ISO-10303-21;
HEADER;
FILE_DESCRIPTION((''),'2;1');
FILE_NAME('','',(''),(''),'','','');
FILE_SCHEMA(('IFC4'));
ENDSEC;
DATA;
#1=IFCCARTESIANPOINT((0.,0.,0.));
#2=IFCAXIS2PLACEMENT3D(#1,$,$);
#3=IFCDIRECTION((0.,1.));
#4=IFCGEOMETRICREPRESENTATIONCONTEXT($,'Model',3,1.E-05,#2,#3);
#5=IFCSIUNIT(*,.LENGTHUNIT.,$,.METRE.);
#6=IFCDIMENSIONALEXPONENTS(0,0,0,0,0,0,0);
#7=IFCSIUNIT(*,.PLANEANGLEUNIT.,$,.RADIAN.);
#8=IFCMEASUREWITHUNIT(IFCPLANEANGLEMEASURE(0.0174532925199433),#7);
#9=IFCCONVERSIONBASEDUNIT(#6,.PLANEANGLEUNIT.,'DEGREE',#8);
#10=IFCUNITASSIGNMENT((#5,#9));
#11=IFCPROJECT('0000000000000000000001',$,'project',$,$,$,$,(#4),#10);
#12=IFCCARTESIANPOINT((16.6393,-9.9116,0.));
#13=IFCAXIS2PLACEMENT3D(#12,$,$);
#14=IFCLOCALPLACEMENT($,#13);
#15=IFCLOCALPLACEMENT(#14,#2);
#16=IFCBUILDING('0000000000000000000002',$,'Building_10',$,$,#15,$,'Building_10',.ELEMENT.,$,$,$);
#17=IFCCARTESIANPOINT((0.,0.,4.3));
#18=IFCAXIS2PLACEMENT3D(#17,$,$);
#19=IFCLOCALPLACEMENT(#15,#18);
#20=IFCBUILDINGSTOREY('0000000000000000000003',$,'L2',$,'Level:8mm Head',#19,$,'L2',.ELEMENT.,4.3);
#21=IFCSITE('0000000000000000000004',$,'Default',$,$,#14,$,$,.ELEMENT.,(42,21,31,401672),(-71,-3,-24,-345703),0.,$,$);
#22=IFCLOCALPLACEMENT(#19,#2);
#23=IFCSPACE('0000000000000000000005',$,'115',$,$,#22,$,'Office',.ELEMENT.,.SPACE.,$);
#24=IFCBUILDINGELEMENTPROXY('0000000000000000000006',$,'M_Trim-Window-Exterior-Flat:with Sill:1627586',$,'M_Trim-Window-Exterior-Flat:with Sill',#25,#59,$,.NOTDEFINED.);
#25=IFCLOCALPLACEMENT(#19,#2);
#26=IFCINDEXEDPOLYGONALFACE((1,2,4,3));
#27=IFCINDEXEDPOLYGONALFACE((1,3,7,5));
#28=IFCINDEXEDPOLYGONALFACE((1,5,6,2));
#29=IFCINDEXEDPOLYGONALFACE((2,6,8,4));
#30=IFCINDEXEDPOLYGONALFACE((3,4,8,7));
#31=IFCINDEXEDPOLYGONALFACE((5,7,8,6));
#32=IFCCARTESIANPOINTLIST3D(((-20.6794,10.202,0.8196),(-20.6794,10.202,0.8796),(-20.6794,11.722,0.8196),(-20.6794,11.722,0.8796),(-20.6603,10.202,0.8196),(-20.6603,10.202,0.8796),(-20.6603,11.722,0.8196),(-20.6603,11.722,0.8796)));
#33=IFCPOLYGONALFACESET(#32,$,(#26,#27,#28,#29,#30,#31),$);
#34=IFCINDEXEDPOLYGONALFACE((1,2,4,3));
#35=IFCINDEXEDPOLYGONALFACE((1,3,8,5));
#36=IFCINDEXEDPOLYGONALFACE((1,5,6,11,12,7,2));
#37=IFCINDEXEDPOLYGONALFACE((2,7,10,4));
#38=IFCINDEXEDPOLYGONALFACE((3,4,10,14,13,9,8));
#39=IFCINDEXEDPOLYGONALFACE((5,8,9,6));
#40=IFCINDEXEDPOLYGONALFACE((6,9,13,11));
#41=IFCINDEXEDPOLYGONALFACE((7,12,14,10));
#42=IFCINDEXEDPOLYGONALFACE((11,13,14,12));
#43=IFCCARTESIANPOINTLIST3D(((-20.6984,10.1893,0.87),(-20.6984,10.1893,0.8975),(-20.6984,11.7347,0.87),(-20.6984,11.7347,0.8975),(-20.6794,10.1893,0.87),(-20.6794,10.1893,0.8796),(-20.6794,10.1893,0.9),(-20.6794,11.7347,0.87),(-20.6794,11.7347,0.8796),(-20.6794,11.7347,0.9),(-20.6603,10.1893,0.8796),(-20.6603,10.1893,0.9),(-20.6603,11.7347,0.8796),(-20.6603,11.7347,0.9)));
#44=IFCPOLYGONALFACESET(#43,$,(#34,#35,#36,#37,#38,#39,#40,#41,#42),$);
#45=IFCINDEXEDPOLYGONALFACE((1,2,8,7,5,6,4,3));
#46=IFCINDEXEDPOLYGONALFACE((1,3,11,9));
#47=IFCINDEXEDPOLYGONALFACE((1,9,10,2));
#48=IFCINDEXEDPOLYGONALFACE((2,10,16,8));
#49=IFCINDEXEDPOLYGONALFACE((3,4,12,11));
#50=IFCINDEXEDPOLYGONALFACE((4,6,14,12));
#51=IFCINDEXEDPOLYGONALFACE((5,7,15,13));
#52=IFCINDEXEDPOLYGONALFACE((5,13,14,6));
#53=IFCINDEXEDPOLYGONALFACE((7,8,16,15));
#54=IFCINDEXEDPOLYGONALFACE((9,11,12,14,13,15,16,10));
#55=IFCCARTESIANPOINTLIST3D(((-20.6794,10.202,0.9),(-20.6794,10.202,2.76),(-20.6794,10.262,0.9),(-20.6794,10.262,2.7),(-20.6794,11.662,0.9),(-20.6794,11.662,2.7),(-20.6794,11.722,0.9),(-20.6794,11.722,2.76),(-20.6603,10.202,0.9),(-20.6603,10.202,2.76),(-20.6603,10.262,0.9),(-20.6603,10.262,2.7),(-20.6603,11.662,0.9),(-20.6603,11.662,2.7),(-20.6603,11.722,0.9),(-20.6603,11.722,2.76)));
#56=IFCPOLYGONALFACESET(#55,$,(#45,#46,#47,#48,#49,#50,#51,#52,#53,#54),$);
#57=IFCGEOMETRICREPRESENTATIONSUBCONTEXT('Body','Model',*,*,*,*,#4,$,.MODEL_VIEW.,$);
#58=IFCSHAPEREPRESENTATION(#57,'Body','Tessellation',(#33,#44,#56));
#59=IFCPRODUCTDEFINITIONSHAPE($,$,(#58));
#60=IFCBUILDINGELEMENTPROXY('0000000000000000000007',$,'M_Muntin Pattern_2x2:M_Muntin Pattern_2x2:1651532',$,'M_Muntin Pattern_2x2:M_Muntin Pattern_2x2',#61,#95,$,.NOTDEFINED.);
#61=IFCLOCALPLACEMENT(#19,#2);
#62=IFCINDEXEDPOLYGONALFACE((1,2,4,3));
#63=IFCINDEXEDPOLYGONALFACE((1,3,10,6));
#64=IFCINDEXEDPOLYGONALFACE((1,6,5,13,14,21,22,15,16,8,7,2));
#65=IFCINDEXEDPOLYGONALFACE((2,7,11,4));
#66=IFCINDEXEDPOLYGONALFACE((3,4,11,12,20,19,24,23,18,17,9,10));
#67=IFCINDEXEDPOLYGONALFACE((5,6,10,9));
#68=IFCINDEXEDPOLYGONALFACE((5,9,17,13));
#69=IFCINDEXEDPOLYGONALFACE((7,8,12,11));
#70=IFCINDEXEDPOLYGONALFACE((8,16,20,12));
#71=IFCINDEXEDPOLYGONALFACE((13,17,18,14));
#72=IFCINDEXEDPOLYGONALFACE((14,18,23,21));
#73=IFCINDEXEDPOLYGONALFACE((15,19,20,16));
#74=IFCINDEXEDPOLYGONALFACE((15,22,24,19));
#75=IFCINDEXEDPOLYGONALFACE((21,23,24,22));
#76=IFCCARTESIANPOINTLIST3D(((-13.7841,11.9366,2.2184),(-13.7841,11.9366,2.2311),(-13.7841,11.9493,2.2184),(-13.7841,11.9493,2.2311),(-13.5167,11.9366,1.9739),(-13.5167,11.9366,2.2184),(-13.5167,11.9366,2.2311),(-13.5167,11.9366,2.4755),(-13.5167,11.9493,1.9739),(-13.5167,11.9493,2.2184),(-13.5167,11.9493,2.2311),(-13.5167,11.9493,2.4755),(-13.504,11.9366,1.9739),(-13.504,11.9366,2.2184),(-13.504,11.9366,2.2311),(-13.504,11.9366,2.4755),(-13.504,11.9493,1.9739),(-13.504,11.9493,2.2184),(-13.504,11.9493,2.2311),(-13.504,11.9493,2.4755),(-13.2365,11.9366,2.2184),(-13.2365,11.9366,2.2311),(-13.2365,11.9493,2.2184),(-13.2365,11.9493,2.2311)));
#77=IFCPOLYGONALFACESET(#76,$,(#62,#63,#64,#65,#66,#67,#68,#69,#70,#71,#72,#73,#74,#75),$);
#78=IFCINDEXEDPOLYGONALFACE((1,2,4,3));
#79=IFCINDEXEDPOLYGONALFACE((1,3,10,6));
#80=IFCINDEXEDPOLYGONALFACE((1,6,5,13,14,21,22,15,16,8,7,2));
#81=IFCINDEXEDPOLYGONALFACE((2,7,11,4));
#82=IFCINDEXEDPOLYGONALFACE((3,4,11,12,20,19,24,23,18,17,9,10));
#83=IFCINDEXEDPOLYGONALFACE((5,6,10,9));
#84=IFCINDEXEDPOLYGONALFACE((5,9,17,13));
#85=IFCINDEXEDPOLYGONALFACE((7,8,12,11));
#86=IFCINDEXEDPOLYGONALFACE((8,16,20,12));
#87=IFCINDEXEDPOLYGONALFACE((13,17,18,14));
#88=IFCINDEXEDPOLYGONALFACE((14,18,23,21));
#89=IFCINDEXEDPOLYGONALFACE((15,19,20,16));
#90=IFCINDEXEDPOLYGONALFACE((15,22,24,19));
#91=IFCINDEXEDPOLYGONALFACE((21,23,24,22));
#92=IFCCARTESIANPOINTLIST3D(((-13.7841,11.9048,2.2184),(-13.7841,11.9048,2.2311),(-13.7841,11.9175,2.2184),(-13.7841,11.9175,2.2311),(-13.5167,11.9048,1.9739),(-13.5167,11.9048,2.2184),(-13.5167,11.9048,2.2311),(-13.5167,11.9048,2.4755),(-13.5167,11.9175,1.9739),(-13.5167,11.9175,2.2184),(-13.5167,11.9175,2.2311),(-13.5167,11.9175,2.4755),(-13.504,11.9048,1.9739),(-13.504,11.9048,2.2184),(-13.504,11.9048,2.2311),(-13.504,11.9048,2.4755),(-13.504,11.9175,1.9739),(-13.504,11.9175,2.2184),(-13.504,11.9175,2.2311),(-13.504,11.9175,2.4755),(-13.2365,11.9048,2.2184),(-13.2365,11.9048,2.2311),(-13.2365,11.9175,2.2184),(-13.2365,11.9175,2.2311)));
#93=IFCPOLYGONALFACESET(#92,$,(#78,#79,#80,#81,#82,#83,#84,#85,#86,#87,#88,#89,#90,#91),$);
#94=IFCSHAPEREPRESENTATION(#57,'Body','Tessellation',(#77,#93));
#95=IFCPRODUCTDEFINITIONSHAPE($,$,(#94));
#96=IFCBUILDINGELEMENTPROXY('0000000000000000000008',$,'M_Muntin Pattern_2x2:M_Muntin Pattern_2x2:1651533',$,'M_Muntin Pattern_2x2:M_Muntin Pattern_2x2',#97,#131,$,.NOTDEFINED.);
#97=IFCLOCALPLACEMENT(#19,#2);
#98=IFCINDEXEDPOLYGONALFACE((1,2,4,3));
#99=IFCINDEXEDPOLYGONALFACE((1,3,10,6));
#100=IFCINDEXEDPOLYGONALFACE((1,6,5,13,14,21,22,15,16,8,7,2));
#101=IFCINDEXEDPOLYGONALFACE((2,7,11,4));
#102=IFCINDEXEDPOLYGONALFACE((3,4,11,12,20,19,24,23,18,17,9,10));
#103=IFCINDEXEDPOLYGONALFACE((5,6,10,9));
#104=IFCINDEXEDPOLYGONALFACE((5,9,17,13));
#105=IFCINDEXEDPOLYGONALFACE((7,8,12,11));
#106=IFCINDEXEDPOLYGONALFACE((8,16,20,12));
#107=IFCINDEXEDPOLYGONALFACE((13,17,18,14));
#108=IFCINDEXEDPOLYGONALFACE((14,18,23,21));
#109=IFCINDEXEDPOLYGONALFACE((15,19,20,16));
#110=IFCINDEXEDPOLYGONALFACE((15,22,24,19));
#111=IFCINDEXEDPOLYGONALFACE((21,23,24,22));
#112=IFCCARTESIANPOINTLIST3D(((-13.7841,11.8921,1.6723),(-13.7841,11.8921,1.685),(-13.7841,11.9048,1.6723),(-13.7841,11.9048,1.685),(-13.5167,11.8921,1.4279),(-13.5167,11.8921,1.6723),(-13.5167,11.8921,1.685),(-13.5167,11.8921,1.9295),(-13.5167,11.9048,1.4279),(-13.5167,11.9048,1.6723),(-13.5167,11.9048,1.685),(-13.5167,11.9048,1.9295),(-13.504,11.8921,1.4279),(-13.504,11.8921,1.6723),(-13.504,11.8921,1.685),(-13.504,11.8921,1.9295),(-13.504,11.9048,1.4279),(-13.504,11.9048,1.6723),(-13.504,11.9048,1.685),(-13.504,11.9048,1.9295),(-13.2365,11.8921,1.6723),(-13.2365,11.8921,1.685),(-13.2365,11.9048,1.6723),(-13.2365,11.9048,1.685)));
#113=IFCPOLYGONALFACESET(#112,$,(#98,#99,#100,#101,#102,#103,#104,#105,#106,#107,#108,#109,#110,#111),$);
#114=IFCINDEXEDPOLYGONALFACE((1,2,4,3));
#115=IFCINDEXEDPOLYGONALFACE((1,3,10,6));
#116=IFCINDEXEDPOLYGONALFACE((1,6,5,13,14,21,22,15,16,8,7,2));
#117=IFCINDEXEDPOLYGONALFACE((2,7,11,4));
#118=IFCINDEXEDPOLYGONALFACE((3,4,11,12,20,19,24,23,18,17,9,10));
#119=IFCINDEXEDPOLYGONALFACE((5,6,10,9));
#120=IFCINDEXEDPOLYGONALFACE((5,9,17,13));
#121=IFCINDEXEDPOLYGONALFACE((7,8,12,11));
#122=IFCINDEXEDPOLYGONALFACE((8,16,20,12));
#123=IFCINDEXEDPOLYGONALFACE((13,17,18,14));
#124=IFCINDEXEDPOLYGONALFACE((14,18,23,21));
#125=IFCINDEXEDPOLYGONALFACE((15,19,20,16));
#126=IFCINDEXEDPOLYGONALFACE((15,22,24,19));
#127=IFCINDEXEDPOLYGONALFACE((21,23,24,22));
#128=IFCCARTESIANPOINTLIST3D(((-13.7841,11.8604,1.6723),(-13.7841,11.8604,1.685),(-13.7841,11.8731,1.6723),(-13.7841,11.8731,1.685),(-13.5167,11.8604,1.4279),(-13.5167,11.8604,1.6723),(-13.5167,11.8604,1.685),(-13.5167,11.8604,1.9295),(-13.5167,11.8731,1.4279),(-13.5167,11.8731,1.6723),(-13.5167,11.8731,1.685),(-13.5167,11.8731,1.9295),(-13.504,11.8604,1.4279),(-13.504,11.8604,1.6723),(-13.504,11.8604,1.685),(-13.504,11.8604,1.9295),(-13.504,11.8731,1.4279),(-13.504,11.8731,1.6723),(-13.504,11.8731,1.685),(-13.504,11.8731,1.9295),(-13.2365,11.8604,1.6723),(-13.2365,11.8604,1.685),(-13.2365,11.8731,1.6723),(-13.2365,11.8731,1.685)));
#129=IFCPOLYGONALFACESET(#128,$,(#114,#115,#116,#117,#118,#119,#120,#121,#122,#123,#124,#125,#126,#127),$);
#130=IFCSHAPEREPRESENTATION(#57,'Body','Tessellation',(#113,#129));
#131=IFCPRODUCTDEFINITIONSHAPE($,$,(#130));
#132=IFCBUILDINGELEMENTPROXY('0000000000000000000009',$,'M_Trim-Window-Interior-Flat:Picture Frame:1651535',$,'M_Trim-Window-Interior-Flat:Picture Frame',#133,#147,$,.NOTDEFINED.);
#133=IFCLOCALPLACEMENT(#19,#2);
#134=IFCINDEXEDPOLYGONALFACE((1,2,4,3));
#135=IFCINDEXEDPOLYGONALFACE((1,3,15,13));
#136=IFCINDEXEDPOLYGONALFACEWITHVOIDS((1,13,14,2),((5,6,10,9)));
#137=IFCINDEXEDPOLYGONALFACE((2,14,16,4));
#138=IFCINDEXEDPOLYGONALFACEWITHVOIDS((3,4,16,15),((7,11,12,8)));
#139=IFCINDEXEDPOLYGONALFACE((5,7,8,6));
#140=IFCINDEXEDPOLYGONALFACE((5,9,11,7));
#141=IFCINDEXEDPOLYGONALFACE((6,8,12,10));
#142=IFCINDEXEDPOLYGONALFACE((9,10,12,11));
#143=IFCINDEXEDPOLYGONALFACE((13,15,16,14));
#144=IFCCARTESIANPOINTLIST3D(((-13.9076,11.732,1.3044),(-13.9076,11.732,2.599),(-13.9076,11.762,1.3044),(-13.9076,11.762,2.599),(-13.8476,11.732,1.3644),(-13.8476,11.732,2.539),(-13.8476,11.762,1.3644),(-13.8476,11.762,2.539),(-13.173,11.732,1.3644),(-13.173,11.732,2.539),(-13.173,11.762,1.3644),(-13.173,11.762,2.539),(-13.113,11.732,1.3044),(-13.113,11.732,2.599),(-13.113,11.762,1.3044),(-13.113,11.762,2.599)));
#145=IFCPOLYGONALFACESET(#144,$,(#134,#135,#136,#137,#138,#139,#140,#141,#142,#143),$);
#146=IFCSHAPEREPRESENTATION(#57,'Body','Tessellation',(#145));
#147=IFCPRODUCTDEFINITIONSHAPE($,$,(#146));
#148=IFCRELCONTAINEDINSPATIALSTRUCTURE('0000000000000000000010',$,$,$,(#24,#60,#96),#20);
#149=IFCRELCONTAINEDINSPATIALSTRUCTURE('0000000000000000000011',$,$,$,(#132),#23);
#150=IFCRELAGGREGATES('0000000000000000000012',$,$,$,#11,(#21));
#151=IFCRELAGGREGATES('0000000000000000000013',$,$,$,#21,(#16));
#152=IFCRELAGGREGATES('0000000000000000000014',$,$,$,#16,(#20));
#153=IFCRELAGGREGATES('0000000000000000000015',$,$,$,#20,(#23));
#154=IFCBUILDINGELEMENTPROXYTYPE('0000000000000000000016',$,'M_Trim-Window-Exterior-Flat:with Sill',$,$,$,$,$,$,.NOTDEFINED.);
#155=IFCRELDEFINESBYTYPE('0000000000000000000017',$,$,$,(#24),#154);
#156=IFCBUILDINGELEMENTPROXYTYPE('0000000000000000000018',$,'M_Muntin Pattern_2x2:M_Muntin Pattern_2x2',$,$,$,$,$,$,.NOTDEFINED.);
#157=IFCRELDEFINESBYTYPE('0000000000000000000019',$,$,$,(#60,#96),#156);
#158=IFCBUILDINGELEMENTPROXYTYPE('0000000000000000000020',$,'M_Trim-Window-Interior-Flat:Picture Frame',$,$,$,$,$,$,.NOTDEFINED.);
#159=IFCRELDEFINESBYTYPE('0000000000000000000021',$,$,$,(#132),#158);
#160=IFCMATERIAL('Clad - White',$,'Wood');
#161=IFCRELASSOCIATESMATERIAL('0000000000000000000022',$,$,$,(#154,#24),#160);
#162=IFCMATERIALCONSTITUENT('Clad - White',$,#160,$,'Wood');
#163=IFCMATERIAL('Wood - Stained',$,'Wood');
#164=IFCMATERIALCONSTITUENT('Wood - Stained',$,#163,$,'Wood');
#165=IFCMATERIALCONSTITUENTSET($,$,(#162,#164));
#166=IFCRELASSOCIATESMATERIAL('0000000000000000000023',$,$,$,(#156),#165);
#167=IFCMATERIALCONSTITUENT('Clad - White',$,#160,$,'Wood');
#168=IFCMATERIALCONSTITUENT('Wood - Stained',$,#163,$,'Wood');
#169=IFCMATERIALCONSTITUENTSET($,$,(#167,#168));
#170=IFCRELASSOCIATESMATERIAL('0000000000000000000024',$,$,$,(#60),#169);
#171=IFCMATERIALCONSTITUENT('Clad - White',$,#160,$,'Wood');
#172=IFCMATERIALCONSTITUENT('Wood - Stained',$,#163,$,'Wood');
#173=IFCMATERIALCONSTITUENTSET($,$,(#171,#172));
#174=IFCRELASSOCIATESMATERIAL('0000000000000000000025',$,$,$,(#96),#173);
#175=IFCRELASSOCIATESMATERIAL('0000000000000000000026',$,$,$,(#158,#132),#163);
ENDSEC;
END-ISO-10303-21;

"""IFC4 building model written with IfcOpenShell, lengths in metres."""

from ifc_helpers import new_model, entity, si_unit, converted_unit, direction, frame, origin, place, context, subcontext, project, spatial, indexed_curve, outline, extrude, source, transform, mapped, material, constituent, constituent_set, type_object, type_shapes, element, save


model = new_model("IFC4")

# Units and contexts
model_context = context("Model", 3, precision=1e-05, world=origin(), true_north=direction((0.0, 1.0)))
body_context = subcontext(model_context, "Body", "Model", "MODEL_VIEW")
ifc_project = project(units=[si_unit("LENGTHUNIT", "METRE"), converted_unit("PLANEANGLEUNIT", "DEGREE", entity("IfcPlaneAngleMeasure", 0.0174532925199433), si_unit("PLANEANGLEUNIT", "RADIAN"), dimensions=[0, 0, 0, 0, 0, 0, 0])], contexts=[model_context])

# Site, building, storey
site_placement = place(None, frame((16.6393, -9.9116, 0.0)))
site = spatial("IfcSite", under=ifc_project, at=site_placement, Name="Default", CompositionType="ELEMENT", RefLatitude=(42, 21, 31, 401672), RefLongitude=(-71, -3, -24, -345703), RefElevation=0.0)
building_placement = place(site_placement, origin())
building = spatial("IfcBuilding", under=site, at=building_placement, Name="Building_10", LongName="Building_10", CompositionType="ELEMENT")
storey_placement = place(building_placement, frame((0.0, 0.0, 4.3)))
storey = spatial("IfcBuildingStorey", under=building, at=storey_placement, Name="L2", ObjectType="Level:8mm Head", LongName="L2", CompositionType="ELEMENT", Elevation=4.3)

# Building element proxies
ifc_material_1 = material(Name="Clad - White", Category="Wood")
ifc_material_2 = material(Name="Wood - Stained", Category="Wood")
building_element_proxy_type_1 = type_object("IfcBuildingElementProxyType", Name="M_Trim-Window-Exterior-Flat:with Sill", PredefinedType="NOTDEFINED", material=ifc_material_1)
shared_shape_1 = source(origin(), body_context, "Body", "SweptSolid", [
    extrude(outline(indexed_curve([(-0.76, -0.03), (0.76, -0.03), (0.76, 0.03), (-0.76, 0.03), (-0.76, -0.03)], self_intersect=False)), frame((0.0, -1.8504, 0.0), z_axis=(0.0, 0.0, 1.0), x_axis=(-1.0, 0.0, 0.0)), (0.0, 0.0, 1.0), 0.0191),
    extrude(outline(indexed_curve([(-0.019, -0.0152), (0.0, -0.0152), (0.0, -0.0057), (0.019, -0.0057), (0.019, 0.0148), (0.0, 0.0148), (-0.019, 0.0123), (-0.019, -0.0152)], self_intersect=False)), frame((-0.7727, -1.8148, 0.019), z_axis=(1.0, 0.0, 0.0), x_axis=(0.0, 0.0, -1.0)), (0.0, 0.0, 1.0), 1.5454),
    extrude(outline(indexed_curve([(-0.945, -0.76), (0.915, -0.76), (0.915, -0.7), (-0.885, -0.7), (-0.885, 0.7), (0.915, 0.7), (0.915, 0.76), (-0.945, 0.76), (-0.945, -0.76)], self_intersect=False)), frame((0.0, -0.885, 0.0), z_axis=(0.0, 0.0, 1.0), x_axis=(0.0, -1.0, 0.0)), (0.0, 0.0, 1.0), 0.0191),
])
type_shapes(building_element_proxy_type_1, [shared_shape_1])
for number, where, z_axis, x_axis, name in (
    (1, (-20.6603, 10.962, 2.7), (-1.0, 0.0, 0.0), (0.0, -1.0, 0.0), "M_Trim-Window-Exterior-Flat:with Sill:1627586"),
):
    element("IfcBuildingElementProxy", number, at=place(storey_placement, frame(where, z_axis=z_axis, x_axis=x_axis)), inside=storey, type_object=building_element_proxy_type_1, material=ifc_material_1, Name=name, ObjectType="M_Trim-Window-Exterior-Flat:with Sill", PredefinedType="NOTDEFINED", context=body_context, shape_type="MappedRepresentation", body=[
        mapped(shared_shape_1, transform((0.0, 0.0, 0.0), scale=1.0)),
    ])
ifc_constituent_1 = constituent(ifc_material_1, Name="Clad - White", Category="Wood")
ifc_constituent_2 = constituent(ifc_material_2, Name="Wood - Stained", Category="Wood")
ifc_constituent_set_1 = constituent_set(constituents=[ifc_constituent_1, ifc_constituent_2])
ifc_constituent_3 = constituent(ifc_material_1, Name="Clad - White", Category="Wood")
ifc_constituent_4 = constituent(ifc_material_2, Name="Wood - Stained", Category="Wood")
ifc_constituent_set_2 = constituent_set(constituents=[ifc_constituent_3, ifc_constituent_4])
building_element_proxy_type_2 = type_object("IfcBuildingElementProxyType", Name="M_Muntin Pattern_2x2:M_Muntin Pattern_2x2", PredefinedType="NOTDEFINED", material=ifc_constituent_set_2)
shared_shape_2 = source(origin(), body_context, "Body", "SweptSolid", [
    extrude(outline(indexed_curve([(0.0064, -0.0064), (0.2508, -0.0064), (0.2508, 0.0063), (0.0064, 0.0063), (0.0064, 0.2738), (-0.0063, 0.2738), (-0.0063, 0.0063), (-0.2508, 0.0063), (-0.2508, -0.0064), (-0.0063, -0.0064), (-0.0063, -0.2738), (0.0064, -0.2738), (0.0064, -0.0064)], self_intersect=False)), frame((0.0, 0.0095, 0.2508), z_axis=(0.0, 1.0, 0.0), x_axis=(0.0, 0.0, 1.0)), (0.0, 0.0, 1.0), 0.0127),
    extrude(outline(indexed_curve([(0.0064, -0.0064), (0.2508, -0.0064), (0.2508, 0.0063), (0.0064, 0.0063), (0.0064, 0.2738), (-0.0063, 0.2738), (-0.0063, 0.0063), (-0.2508, 0.0063), (-0.2508, -0.0064), (-0.0063, -0.0064), (-0.0063, -0.2738), (0.0064, -0.2738), (0.0064, -0.0064)], self_intersect=False)), frame((0.0, -0.0222, 0.2508), z_axis=(0.0, 1.0, 0.0), x_axis=(0.0, 0.0, 1.0)), (0.0, 0.0, 1.0), 0.0127),
])
type_shapes(building_element_proxy_type_2, [shared_shape_2])
proxy_1_placement = place(storey_placement, frame((-13.5103, 11.927, 1.9739)))
element("IfcBuildingElementProxy", 2, at=proxy_1_placement, inside=storey, type_object=building_element_proxy_type_2, material=ifc_constituent_set_1, Name="M_Muntin Pattern_2x2:M_Muntin Pattern_2x2:1651532", ObjectType="M_Muntin Pattern_2x2:M_Muntin Pattern_2x2", PredefinedType="NOTDEFINED", context=body_context, shape_type="MappedRepresentation", body=[
    mapped(shared_shape_2, transform((0.0, 0.0, 0.0), scale=1.0)),
])
ifc_constituent_5 = constituent(ifc_material_1, Name="Clad - White", Category="Wood")
ifc_constituent_6 = constituent(ifc_material_2, Name="Wood - Stained", Category="Wood")
ifc_constituent_set_3 = constituent_set(constituents=[ifc_constituent_5, ifc_constituent_6])
proxy_2_placement = place(storey_placement, frame((-13.5103, 11.8826, 1.4279)))
element("IfcBuildingElementProxy", 3, at=proxy_2_placement, inside=storey, type_object=building_element_proxy_type_2, material=ifc_constituent_set_3, Name="M_Muntin Pattern_2x2:M_Muntin Pattern_2x2:1651533", ObjectType="M_Muntin Pattern_2x2:M_Muntin Pattern_2x2", PredefinedType="NOTDEFINED", context=body_context, shape_type="MappedRepresentation", body=[
    mapped(shared_shape_2, transform((0.0, 0.0, 0.0), scale=1.0)),
])

# Shared definitions
space_placement = place(storey_placement, origin())
space = spatial("IfcSpace", under=storey, at=space_placement, Name="115", LongName="Office", CompositionType="ELEMENT", PredefinedType="SPACE")

# Building element proxy
building_element_proxy_type_3 = type_object("IfcBuildingElementProxyType", Name="M_Trim-Window-Interior-Flat:Picture Frame", PredefinedType="NOTDEFINED", material=ifc_material_2)
shared_shape_3 = source(origin(), body_context, "Body", "SweptSolid", [
    extrude(outline(indexed_curve([(-0.3973, -0.6473), (0.3973, -0.6473), (0.3973, 0.6473), (-0.3973, 0.6473), (-0.3973, -0.6473)], self_intersect=False), holes=[indexed_curve([(-0.3373, -0.5873), (-0.3373, 0.5873), (0.3373, 0.5873), (0.3373, -0.5873), (-0.3373, -0.5873)], self_intersect=False)]), frame((0.0, -0.6, 0.0), z_axis=(0.0, 0.0, 1.0), x_axis=(-1.0, 0.0, 0.0)), (0.0, 0.0, 1.0), 0.03),
])
type_shapes(building_element_proxy_type_3, [shared_shape_3])
proxy_3_placement = place(space_placement, frame((-13.5103, 11.762, 2.5517), z_axis=(0.0, -1.0, 0.0), x_axis=(1.0, 0.0, 0.0)))
element("IfcBuildingElementProxy", 4, at=proxy_3_placement, inside=space, type_object=building_element_proxy_type_3, material=ifc_material_2, Name="M_Trim-Window-Interior-Flat:Picture Frame:1651535", ObjectType="M_Trim-Window-Interior-Flat:Picture Frame", PredefinedType="NOTDEFINED", context=body_context, shape_type="MappedRepresentation", body=[
    mapped(shared_shape_3, transform((0.0, 0.0, 0.0), scale=1.0)),
])

save(model, "model.ifc")
